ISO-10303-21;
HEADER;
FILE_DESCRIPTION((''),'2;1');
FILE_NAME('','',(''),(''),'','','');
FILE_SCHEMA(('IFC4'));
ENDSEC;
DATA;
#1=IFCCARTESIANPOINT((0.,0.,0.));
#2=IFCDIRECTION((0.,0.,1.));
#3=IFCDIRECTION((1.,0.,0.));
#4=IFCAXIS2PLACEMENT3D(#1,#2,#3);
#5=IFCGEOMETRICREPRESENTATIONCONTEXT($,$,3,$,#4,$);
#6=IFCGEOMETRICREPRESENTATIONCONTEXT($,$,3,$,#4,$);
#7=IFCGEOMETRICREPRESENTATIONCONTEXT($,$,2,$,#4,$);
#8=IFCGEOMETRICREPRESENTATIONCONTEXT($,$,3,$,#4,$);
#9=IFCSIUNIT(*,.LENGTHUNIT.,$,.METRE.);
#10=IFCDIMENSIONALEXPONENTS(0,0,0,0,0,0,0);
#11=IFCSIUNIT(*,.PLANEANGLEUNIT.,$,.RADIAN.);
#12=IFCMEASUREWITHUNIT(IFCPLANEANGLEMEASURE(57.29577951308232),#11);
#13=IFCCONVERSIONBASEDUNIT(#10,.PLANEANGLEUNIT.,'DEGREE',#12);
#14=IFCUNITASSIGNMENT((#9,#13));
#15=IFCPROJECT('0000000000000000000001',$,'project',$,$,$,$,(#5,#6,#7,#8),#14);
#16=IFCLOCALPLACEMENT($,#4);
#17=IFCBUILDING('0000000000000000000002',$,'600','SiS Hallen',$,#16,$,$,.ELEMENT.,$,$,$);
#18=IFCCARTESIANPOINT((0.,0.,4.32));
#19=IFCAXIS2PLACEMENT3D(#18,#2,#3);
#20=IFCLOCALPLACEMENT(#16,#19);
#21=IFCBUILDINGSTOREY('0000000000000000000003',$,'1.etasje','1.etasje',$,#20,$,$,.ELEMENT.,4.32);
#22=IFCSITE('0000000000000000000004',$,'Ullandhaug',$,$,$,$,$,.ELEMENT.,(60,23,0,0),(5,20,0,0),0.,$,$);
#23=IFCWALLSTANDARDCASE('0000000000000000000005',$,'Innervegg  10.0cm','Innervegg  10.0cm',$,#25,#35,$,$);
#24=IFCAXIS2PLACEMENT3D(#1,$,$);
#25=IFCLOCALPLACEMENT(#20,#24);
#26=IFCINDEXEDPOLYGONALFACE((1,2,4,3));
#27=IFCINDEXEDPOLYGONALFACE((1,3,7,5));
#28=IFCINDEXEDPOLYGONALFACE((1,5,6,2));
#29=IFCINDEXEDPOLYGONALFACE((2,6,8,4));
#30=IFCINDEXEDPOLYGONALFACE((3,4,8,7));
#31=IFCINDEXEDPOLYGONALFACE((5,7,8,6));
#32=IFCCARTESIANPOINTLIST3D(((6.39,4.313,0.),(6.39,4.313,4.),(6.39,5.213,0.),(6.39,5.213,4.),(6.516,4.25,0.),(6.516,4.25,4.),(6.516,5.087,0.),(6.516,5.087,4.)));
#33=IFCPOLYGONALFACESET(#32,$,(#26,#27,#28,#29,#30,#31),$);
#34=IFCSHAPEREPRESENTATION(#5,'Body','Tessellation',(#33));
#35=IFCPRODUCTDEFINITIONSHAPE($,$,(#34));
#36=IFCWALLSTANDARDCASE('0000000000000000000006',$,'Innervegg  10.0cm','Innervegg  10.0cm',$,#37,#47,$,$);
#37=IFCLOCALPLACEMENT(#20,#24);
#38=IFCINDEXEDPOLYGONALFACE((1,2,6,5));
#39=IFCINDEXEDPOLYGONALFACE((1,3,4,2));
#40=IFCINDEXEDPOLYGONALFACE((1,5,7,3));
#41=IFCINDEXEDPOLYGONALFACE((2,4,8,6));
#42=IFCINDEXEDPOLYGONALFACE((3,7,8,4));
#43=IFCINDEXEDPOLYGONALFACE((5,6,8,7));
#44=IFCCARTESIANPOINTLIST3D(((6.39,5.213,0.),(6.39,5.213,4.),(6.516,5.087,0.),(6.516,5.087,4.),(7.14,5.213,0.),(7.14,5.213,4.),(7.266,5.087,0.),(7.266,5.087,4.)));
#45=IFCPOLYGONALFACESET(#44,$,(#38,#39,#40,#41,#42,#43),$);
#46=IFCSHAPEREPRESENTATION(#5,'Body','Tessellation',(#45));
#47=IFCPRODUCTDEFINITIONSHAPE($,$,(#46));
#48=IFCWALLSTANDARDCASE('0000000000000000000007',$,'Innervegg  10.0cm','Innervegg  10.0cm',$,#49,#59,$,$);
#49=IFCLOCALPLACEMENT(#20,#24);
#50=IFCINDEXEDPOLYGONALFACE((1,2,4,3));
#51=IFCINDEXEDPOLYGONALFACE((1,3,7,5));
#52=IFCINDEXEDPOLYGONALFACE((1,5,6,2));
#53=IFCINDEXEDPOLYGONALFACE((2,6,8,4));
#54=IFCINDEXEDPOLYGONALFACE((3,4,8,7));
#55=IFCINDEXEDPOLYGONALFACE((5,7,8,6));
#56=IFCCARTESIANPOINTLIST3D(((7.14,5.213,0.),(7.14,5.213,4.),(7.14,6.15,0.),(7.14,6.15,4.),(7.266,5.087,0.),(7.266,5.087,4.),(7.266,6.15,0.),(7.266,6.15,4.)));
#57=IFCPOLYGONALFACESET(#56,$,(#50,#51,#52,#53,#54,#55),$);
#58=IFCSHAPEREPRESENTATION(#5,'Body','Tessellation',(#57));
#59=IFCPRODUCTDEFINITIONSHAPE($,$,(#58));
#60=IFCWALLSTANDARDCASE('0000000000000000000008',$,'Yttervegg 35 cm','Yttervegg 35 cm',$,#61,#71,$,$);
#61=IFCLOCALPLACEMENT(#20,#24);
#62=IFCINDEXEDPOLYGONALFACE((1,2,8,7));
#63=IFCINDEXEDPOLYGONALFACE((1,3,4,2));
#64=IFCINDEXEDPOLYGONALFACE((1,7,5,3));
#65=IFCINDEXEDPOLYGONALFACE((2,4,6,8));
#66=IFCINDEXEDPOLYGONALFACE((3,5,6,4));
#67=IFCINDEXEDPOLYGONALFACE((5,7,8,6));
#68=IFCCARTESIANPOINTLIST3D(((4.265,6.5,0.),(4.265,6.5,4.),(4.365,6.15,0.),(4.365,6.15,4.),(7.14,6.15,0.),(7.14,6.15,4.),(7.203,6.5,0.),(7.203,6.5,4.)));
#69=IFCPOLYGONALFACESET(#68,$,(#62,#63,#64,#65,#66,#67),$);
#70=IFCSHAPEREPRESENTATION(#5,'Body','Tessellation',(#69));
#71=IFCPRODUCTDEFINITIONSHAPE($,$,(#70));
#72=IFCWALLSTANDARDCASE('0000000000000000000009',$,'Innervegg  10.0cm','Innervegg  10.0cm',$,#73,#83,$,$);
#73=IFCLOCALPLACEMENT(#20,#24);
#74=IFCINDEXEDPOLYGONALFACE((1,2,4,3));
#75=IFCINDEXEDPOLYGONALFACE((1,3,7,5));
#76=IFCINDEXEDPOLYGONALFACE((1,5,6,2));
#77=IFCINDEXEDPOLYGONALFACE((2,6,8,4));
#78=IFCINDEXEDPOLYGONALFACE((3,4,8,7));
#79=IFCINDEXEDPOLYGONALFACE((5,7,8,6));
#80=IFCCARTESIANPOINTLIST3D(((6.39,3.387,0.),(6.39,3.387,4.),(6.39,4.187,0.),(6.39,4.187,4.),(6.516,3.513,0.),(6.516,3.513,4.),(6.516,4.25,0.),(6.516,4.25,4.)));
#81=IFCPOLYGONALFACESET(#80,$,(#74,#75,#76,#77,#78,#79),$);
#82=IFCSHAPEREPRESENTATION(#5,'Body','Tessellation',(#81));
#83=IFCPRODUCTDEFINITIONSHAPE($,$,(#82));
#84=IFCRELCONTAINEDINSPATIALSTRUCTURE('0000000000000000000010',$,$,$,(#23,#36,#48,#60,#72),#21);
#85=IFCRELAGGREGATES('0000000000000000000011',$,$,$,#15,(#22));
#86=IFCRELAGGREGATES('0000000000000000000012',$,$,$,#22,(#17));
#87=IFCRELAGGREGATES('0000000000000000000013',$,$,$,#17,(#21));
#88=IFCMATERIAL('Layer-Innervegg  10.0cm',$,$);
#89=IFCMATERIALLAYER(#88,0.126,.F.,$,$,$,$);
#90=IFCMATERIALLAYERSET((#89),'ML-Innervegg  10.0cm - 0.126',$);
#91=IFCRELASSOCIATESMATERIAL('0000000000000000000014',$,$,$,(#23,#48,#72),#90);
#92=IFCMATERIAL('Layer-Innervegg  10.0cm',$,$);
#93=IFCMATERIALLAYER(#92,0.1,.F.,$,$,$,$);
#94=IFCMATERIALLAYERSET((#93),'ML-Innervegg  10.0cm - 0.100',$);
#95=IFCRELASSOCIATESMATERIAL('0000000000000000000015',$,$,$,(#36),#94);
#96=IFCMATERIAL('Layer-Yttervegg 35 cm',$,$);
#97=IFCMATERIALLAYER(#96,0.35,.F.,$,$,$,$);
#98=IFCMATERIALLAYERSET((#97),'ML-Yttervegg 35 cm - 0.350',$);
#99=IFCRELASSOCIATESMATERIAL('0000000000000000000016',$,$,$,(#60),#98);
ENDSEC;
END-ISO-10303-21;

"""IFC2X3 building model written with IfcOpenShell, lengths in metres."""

from ifc_helpers import new_model, entity, si_unit, converted_unit, frame, origin_with_axes, place, context, project, spatial, polyline, outline, extrude, material, layer, layer_set, layer_usage, element, save


model = new_model("IFC2X3")

# Units and contexts
context_of_model_1 = context(None, 3, world=origin_with_axes())
context_of_model_2 = context(None, 3, world=origin_with_axes())
context_of_model_3 = context(None, 2, world=origin_with_axes())
context_of_model_4 = context(None, 3, world=origin_with_axes())
ifc_project = project(units=[si_unit("LENGTHUNIT", "METRE"), converted_unit("PLANEANGLEUNIT", "DEGREE", entity("IfcPlaneAngleMeasure", 57.29577951308232), si_unit("PLANEANGLEUNIT", "RADIAN"), dimensions=[0, 0, 0, 0, 0, 0, 0])], contexts=[context_of_model_1, context_of_model_2, context_of_model_3, context_of_model_4])

# Site, building, storey
site = spatial("IfcSite", under=ifc_project, Name="Ullandhaug", CompositionType="ELEMENT", RefLatitude=(60, 23, 0, 0), RefLongitude=(5, 20, 0, 0), RefElevation=0.0)
building_placement = place(None, origin_with_axes())
building = spatial("IfcBuilding", under=site, at=building_placement, Name="600", Description="SiS Hallen", CompositionType="ELEMENT")
storey_placement = place(building_placement, frame((0.0, 0.0, 4.32), z_axis=(0.0, 0.0, 1.0), x_axis=(1.0, 0.0, 0.0)))
storey = spatial("IfcBuildingStorey", under=building, at=storey_placement, Name="1.etasje", Description="1.etasje", CompositionType="ELEMENT", Elevation=4.32)

# Shared definitions
ifc_material_1 = material(Name="Layer-Innervegg  10.0cm")
ifc_layer_1 = layer(ifc_material_1, 0.126, ventilated=False)
ifc_layer_set_1 = layer_set([ifc_layer_1], Name="ML-Innervegg  10.0cm - 0.126")
ifc_layer_usage_1 = layer_usage(ifc_layer_set_1, "AXIS2", "POSITIVE", 0.0)

# Shared definitions
ifc_material_2 = material(Name="Layer-Innervegg  10.0cm")
ifc_layer_2 = layer(ifc_material_2, 0.1, ventilated=False)
ifc_layer_set_2 = layer_set([ifc_layer_2], Name="ML-Innervegg  10.0cm - 0.100")
ifc_layer_usage_2 = layer_usage(ifc_layer_set_2, "AXIS2", "POSITIVE", 0.0)

# Shared definitions
ifc_material_3 = material(Name="Layer-Yttervegg 35 cm")
ifc_layer_3 = layer(ifc_material_3, 0.35, ventilated=False)
ifc_layer_set_3 = layer_set([ifc_layer_3], Name="ML-Yttervegg 35 cm - 0.350")
ifc_layer_usage_3 = layer_usage(ifc_layer_set_3, "AXIS2", "POSITIVE", 0.0)

# Walls
wall_1_placement = place(storey_placement, frame((6.516, 4.25, 0.0), z_axis=(0.0, 0.0, 1.0), x_axis=(0.0, 1.0, 0.0)))
element("IfcWallStandardCase", 1, at=wall_1_placement, inside=storey, material=ifc_layer_usage_1, Name="Innervegg  10.0cm", Description="Innervegg  10.0cm", context=context_of_model_1, shape_type="SweptSolid", body=[
    extrude(outline(polyline([(0.0, 0.0), (0.837, 0.0), (0.963, 0.126), (0.063, 0.126), (0.0, 0.0)])), frame((0.0, 0.0, 0.0), z_axis=(0.0, 0.0, 1.0), x_axis=(1.0, 0.0, 0.0)), (0.0, 0.0, 1.0), 4.0),
])
wall_2_placement = place(storey_placement, frame((6.516, 5.087, 0.0), z_axis=(0.0, 0.0, 1.0), x_axis=(1.0, 0.0, 0.0)))
element("IfcWallStandardCase", 2, at=wall_2_placement, inside=storey, material=ifc_layer_usage_2, Name="Innervegg  10.0cm", Description="Innervegg  10.0cm", context=context_of_model_1, shape_type="SweptSolid", body=[
    extrude(outline(polyline([(0.0, 0.0), (0.75, 0.0), (0.624, 0.126), (-0.126, 0.126), (0.0, 0.0)])), origin_with_axes(), (0.0, 0.0, 1.0), 4.0),
])
wall_3_placement = place(storey_placement, frame((7.266, 5.087, 0.0), z_axis=(0.0, 0.0, 1.0), x_axis=(0.0, 1.0, 0.0)))
element("IfcWallStandardCase", 3, at=wall_3_placement, inside=storey, material=ifc_layer_usage_1, Name="Innervegg  10.0cm", Description="Innervegg  10.0cm", context=context_of_model_1, shape_type="SweptSolid", body=[
    extrude(outline(polyline([(0.0, 0.0), (1.063, 0.0), (1.063, 0.126), (0.126, 0.126), (0.0, 0.0)])), frame((0.0, 0.0, 0.0), z_axis=(0.0, 0.0, 1.0), x_axis=(1.0, 0.0, 0.0)), (0.0, 0.0, 1.0), 4.0),
])
wall_4_placement = place(storey_placement, frame((7.203, 6.5, 0.0), z_axis=(0.0, 0.0, 1.0), x_axis=(-1.0, 0.0, 0.0)))
element("IfcWallStandardCase", 4, at=wall_4_placement, inside=storey, material=ifc_layer_usage_3, Name="Yttervegg 35 cm", Description="Yttervegg 35 cm", context=context_of_model_1, shape_type="SweptSolid", body=[
    extrude(outline(polyline([(0.0, 0.0), (2.938, 0.0), (2.838, 0.35), (0.063, 0.35), (0.0, 0.0)])), frame((0.0, 0.0, 0.0), z_axis=(0.0, 0.0, 1.0), x_axis=(1.0, 0.0, 0.0)), (0.0, 0.0, 1.0), 4.0),
])
wall_5_placement = place(storey_placement, frame((6.516, 3.513, 0.0), z_axis=(0.0, 0.0, 1.0), x_axis=(0.0, 1.0, 0.0)))
element("IfcWallStandardCase", 5, at=wall_5_placement, inside=storey, material=ifc_layer_usage_1, Name="Innervegg  10.0cm", Description="Innervegg  10.0cm", context=context_of_model_1, shape_type="SweptSolid", body=[
    extrude(outline(polyline([(0.0, 0.0), (0.737, 0.0), (0.674, 0.126), (-0.126, 0.126), (0.0, 0.0)])), frame((0.0, 0.0, 0.0), z_axis=(0.0, 0.0, 1.0), x_axis=(1.0, 0.0, 0.0)), (0.0, 0.0, 1.0), 4.0),
])

save(model, "model.ifc")
